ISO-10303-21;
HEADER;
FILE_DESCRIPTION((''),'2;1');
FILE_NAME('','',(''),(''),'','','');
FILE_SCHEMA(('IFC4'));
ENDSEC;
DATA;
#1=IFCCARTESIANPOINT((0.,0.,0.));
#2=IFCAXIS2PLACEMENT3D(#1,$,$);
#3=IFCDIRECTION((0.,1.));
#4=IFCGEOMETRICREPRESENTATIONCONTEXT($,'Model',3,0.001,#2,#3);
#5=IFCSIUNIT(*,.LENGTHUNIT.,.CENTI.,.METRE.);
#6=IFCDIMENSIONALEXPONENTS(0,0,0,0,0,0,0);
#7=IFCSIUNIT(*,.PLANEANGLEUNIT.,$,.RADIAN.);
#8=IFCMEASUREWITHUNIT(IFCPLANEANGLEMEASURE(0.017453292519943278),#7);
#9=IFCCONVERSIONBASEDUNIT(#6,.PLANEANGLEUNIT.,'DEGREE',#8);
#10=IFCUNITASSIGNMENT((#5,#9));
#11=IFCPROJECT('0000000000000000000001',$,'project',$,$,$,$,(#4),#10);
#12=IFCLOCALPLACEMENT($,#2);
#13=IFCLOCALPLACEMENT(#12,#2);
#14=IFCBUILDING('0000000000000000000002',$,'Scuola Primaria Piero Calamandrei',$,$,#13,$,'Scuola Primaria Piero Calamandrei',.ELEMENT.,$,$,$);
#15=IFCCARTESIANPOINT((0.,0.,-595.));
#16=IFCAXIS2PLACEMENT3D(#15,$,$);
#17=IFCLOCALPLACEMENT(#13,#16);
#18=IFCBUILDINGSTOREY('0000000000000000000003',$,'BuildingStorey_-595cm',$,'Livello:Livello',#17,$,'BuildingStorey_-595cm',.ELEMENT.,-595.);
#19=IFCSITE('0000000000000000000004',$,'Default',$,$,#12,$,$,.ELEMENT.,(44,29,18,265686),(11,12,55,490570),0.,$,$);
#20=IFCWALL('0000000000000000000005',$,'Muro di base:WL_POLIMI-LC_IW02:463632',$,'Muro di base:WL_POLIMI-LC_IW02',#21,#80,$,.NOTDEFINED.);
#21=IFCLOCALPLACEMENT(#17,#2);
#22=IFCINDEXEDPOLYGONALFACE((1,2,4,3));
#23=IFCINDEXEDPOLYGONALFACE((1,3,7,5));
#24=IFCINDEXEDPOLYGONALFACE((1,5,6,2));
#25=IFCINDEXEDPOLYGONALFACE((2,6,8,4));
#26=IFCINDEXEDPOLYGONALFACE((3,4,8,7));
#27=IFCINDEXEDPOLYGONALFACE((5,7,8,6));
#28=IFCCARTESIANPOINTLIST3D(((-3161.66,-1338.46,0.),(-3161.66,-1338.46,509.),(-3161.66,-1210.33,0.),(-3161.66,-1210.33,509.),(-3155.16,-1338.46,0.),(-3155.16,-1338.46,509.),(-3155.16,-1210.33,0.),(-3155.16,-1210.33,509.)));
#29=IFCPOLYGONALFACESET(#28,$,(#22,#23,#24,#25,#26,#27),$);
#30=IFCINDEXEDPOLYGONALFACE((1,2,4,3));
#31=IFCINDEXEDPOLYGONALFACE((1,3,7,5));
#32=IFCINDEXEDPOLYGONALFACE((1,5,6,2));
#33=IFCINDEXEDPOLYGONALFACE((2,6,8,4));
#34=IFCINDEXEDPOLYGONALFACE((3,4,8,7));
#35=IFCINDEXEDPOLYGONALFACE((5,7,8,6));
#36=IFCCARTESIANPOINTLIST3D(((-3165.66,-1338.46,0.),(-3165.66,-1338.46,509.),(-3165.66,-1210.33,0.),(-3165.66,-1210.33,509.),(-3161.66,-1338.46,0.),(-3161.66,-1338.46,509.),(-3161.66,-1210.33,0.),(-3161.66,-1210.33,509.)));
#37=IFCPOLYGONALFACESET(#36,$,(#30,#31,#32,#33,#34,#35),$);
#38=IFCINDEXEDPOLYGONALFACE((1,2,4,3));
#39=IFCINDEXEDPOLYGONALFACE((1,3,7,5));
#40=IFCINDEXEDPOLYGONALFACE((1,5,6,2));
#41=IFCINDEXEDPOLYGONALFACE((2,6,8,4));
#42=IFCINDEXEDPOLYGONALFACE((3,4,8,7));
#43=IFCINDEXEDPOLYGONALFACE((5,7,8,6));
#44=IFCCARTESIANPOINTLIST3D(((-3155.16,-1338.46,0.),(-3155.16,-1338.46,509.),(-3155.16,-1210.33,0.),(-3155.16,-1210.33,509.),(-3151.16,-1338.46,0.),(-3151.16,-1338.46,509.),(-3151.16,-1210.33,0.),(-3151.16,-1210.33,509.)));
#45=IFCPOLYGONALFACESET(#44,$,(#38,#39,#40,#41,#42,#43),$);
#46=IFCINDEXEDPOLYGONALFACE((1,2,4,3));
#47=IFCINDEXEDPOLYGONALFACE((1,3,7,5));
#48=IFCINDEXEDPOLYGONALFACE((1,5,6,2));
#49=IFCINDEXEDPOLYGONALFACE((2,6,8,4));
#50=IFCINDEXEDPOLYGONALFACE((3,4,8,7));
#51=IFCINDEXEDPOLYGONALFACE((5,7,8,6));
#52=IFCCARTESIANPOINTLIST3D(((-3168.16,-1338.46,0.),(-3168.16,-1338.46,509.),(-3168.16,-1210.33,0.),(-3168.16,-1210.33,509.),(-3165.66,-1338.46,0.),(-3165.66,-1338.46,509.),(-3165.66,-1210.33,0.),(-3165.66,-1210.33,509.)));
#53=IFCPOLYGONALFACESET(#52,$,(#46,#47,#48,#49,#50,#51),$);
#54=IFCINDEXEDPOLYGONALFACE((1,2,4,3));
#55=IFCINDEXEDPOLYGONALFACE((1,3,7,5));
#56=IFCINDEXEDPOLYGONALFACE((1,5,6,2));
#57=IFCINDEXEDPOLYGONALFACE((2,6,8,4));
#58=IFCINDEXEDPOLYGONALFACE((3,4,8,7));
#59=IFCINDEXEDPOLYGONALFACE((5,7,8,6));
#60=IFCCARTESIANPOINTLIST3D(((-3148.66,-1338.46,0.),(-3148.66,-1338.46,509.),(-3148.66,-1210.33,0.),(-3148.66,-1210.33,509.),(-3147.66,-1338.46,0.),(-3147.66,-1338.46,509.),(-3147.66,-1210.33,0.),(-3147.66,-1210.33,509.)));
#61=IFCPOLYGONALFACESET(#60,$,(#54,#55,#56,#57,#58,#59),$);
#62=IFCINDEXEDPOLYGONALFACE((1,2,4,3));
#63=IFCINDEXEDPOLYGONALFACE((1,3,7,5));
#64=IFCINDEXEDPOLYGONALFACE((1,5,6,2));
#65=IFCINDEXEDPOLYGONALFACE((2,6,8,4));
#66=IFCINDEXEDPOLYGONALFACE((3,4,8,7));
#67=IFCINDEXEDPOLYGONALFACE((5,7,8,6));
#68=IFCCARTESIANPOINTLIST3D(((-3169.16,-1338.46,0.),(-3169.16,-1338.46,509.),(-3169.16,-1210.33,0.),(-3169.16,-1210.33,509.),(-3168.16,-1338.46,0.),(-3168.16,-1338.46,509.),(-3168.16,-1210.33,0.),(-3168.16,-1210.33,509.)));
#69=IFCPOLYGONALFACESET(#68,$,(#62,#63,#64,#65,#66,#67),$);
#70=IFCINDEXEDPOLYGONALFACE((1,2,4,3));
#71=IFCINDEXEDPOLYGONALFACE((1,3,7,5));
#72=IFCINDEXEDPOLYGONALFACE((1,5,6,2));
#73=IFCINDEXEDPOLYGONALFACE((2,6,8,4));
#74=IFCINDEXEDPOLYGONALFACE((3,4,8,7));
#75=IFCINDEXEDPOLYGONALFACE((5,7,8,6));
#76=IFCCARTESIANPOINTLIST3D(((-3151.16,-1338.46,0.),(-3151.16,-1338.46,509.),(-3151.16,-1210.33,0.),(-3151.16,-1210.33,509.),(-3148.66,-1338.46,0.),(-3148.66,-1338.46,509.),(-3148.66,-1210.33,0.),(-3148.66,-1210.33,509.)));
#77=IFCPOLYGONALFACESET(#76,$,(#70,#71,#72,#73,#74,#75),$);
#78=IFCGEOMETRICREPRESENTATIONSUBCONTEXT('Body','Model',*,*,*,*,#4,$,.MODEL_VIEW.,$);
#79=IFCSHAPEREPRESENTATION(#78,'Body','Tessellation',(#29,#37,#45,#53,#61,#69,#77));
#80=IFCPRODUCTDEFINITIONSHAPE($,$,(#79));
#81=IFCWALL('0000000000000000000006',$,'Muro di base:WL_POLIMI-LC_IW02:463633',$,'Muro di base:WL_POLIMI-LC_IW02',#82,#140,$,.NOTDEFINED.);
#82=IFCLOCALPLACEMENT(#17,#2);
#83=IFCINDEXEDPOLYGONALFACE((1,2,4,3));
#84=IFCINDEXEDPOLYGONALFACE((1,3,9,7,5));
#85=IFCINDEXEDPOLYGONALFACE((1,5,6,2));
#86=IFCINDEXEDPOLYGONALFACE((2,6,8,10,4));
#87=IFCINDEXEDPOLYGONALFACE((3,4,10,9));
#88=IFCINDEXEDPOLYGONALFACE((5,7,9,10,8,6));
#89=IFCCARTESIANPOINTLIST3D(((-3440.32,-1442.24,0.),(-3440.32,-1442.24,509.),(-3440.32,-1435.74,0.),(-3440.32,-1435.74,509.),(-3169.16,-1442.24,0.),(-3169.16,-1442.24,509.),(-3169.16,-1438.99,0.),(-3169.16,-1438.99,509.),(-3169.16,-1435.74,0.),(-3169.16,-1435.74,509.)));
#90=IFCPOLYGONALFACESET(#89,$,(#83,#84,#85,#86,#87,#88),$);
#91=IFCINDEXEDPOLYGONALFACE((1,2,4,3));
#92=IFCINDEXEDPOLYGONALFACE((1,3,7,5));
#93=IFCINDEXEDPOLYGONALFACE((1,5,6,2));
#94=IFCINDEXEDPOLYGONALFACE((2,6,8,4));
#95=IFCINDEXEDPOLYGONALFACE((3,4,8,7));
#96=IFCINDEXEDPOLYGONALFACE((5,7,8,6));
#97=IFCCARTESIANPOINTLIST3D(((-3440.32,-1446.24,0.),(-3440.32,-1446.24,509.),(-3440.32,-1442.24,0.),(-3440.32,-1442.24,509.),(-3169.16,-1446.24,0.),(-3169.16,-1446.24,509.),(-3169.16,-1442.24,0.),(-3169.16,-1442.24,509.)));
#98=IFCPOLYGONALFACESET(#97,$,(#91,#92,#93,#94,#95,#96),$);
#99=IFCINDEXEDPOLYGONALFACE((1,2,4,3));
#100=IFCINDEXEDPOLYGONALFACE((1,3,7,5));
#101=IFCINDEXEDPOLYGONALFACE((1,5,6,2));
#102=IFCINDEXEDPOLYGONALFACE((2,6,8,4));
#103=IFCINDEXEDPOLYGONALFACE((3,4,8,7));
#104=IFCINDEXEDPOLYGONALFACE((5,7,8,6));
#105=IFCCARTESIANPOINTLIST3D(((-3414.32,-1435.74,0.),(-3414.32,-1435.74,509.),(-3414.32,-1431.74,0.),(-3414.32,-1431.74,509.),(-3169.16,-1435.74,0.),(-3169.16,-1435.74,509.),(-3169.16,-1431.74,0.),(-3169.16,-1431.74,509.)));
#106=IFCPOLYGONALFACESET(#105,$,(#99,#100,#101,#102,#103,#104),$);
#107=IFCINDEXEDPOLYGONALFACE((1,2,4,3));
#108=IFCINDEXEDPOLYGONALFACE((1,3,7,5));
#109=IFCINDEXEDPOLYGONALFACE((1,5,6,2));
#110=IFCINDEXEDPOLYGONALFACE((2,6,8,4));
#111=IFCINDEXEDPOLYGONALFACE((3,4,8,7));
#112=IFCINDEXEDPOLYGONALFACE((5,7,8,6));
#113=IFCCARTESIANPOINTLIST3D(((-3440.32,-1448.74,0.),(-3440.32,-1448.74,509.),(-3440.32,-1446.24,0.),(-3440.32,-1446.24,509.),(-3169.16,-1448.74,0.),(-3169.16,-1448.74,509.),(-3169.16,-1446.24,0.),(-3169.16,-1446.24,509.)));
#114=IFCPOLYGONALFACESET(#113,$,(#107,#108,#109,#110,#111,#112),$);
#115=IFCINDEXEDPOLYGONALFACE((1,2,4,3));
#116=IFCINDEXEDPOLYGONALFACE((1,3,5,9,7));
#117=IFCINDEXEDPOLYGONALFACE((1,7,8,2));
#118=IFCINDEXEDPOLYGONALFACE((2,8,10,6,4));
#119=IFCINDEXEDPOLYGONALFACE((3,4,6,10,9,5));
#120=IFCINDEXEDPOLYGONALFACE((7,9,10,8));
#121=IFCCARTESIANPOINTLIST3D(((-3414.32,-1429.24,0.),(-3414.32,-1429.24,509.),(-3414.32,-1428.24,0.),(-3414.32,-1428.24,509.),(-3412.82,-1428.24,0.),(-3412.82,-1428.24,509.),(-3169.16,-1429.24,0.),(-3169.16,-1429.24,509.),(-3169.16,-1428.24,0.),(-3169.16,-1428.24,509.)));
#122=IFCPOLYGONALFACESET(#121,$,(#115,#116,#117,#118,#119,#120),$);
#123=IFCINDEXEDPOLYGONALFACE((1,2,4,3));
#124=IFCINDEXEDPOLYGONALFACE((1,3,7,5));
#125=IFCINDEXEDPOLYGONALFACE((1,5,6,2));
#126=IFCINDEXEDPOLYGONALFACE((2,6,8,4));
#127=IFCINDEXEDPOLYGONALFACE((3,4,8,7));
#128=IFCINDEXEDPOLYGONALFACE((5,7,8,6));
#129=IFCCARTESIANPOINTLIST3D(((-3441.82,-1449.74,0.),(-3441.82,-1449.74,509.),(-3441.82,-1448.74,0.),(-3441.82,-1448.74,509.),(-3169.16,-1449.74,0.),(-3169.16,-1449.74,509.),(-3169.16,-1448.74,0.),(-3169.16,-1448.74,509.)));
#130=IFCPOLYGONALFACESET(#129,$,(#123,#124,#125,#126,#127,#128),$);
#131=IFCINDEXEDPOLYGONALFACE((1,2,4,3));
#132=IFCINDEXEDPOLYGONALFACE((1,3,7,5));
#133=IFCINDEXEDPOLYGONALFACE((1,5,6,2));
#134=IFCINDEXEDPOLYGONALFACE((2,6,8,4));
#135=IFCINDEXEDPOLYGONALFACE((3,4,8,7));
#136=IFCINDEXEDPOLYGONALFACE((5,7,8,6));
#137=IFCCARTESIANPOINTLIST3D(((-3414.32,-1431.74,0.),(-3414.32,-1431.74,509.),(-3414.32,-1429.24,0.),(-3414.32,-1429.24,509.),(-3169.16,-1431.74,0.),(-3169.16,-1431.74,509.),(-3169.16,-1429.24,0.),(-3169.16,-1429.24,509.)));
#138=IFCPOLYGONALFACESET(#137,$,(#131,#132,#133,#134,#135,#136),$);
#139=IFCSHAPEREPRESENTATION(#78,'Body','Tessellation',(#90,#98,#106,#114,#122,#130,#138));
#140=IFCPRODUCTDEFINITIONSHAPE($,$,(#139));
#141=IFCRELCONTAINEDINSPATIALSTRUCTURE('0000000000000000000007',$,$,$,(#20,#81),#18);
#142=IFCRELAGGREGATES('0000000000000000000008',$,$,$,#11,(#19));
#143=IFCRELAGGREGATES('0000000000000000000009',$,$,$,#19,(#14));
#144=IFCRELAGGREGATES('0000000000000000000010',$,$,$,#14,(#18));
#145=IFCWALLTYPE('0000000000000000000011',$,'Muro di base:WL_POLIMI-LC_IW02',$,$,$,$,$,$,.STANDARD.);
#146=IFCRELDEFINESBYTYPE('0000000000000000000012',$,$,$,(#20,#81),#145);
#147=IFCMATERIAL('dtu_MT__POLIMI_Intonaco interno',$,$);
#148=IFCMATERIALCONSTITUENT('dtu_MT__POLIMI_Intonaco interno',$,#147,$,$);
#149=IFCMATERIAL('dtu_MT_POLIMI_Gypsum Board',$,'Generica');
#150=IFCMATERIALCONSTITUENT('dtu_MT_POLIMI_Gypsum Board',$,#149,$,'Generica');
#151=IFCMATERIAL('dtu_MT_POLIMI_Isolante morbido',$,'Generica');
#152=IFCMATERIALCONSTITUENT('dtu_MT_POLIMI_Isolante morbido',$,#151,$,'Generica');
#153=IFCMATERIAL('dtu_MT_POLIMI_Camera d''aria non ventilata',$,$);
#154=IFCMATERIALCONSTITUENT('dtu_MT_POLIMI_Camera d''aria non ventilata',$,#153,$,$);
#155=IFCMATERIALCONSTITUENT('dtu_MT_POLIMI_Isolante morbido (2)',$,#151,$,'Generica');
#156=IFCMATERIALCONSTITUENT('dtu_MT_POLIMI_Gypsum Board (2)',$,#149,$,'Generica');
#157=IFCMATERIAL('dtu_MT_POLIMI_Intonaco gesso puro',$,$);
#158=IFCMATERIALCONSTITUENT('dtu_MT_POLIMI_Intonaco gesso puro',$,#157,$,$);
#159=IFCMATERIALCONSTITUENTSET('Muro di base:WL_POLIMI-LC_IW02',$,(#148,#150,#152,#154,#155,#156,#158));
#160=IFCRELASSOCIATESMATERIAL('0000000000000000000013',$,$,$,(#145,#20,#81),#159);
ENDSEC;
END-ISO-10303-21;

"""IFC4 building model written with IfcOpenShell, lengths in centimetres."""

from ifc_helpers import new_model, entity, si_unit, converted_unit, direction, frame, origin, place, context, subcontext, project, spatial, indexed_curve, outline, extrude, material, constituent, constituent_set, type_object, element, save


model = new_model("IFC4")

# Units and contexts
model_context = context("Model", 3, precision=0.001, world=origin(), true_north=direction((0.0, 1.0)))
body_context = subcontext(model_context, "Body", "Model", "MODEL_VIEW")
ifc_project = project(units=[si_unit("LENGTHUNIT", "METRE", prefix="CENTI"), converted_unit("PLANEANGLEUNIT", "DEGREE", entity("IfcPlaneAngleMeasure", 0.017453292519943278), si_unit("PLANEANGLEUNIT", "RADIAN"), dimensions=[0, 0, 0, 0, 0, 0, 0])], contexts=[model_context])

# Site, building, storey
site_placement = place(None, origin())
site = spatial("IfcSite", under=ifc_project, at=site_placement, Name="Default", CompositionType="ELEMENT", RefLatitude=(44, 29, 18, 265686), RefLongitude=(11, 12, 55, 490570), RefElevation=0.0)
building_placement = place(site_placement, origin())
building = spatial("IfcBuilding", under=site, at=building_placement, Name="Scuola Primaria Piero Calamandrei", LongName="Scuola Primaria Piero Calamandrei", CompositionType="ELEMENT")
storey_placement = place(building_placement, frame((0.0, 0.0, -595.0)))
storey = spatial("IfcBuildingStorey", under=building, at=storey_placement, Name="BuildingStorey_-595cm", ObjectType="Livello:Livello", LongName="BuildingStorey_-595cm", CompositionType="ELEMENT", Elevation=-595.0)

# Shared definitions
ifc_material_1 = material(Name="dtu_MT__POLIMI_Intonaco interno")

# Shared definitions
ifc_constituent_1 = constituent(ifc_material_1, Name="dtu_MT__POLIMI_Intonaco interno")
ifc_material_2 = material(Name="dtu_MT_POLIMI_Gypsum Board", Category="Generica")
ifc_constituent_2 = constituent(ifc_material_2, Name="dtu_MT_POLIMI_Gypsum Board", Category="Generica")
ifc_material_3 = material(Name="dtu_MT_POLIMI_Isolante morbido", Category="Generica")
ifc_constituent_3 = constituent(ifc_material_3, Name="dtu_MT_POLIMI_Isolante morbido", Category="Generica")
ifc_material_4 = material(Name="dtu_MT_POLIMI_Camera d'aria non ventilata")
ifc_constituent_4 = constituent(ifc_material_4, Name="dtu_MT_POLIMI_Camera d'aria non ventilata")
ifc_constituent_5 = constituent(ifc_material_3, Name="dtu_MT_POLIMI_Isolante morbido (2)", Category="Generica")
ifc_constituent_6 = constituent(ifc_material_2, Name="dtu_MT_POLIMI_Gypsum Board (2)", Category="Generica")
ifc_material_5 = material(Name="dtu_MT_POLIMI_Intonaco gesso puro")
ifc_constituent_7 = constituent(ifc_material_5, Name="dtu_MT_POLIMI_Intonaco gesso puro")
ifc_constituent_set_1 = constituent_set(constituents=[ifc_constituent_1, ifc_constituent_2, ifc_constituent_3, ifc_constituent_4, ifc_constituent_5, ifc_constituent_6, ifc_constituent_7], Name="Muro di base:WL_POLIMI-LC_IW02")
wall_type_1 = type_object("IfcWallType", Name="Muro di base:WL_POLIMI-LC_IW02", PredefinedType="STANDARD", material=ifc_constituent_set_1)

# Walls
wall_1_placement = place(storey_placement, frame((-3158.41, -1338.46, 0.0), z_axis=(0.0, 0.0, 1.0), x_axis=(0.0, 1.0, 0.0)))
element("IfcWall", 1, at=wall_1_placement, inside=storey, type_object=wall_type_1, material=ifc_constituent_set_1, Name="Muro di base:WL_POLIMI-LC_IW02:463632", ObjectType="Muro di base:WL_POLIMI-LC_IW02", PredefinedType="NOTDEFINED", context=body_context, shape_type="SweptSolid", body=[
    extrude(outline(indexed_curve([(-64.07, -3.25), (64.07, -3.25), (64.07, 3.25), (-64.07, 3.25), (-64.07, -3.25)], self_intersect=False)), frame((64.07, 0.0, 0.0)), (0.0, 0.0, 1.0), 509.0),
    extrude(outline(indexed_curve([(-64.07, -2.0), (64.07, -2.0), (64.07, 2.0), (-64.07, 2.0), (-64.07, -2.0)], self_intersect=False)), frame((64.07, 5.25, 0.0)), (0.0, 0.0, 1.0), 509.0),
    extrude(outline(indexed_curve([(-64.07, -2.0), (64.07, -2.0), (64.07, 2.0), (-64.07, 2.0), (-64.07, -2.0)], self_intersect=False)), frame((64.07, -5.25, 0.0)), (0.0, 0.0, 1.0), 509.0),
    extrude(outline(indexed_curve([(-64.07, -1.25), (64.07, -1.25), (64.07, 1.25), (-64.07, 1.25), (-64.07, -1.25)], self_intersect=False)), frame((64.07, 8.5, 0.0)), (0.0, 0.0, 1.0), 509.0),
    extrude(outline(indexed_curve([(-0.5, -64.07), (0.5, -64.07), (0.5, 64.07), (-0.5, 64.07), (-0.5, -64.07)], self_intersect=False)), frame((64.07, -10.25, 0.0), z_axis=(0.0, 0.0, 1.0), x_axis=(0.0, 1.0, 0.0)), (0.0, 0.0, 1.0), 509.0),
    extrude(outline(indexed_curve([(-0.5, -64.07), (0.5, -64.07), (0.5, 64.07), (-0.5, 64.07), (-0.5, -64.07)], self_intersect=False)), frame((64.07, 10.25, 0.0), z_axis=(0.0, 0.0, 1.0), x_axis=(0.0, -1.0, 0.0)), (0.0, 0.0, 1.0), 509.0),
    extrude(outline(indexed_curve([(-64.07, -1.25), (64.07, -1.25), (64.07, 1.25), (-64.07, 1.25), (-64.07, -1.25)], self_intersect=False)), frame((64.07, -8.5, 0.0)), (0.0, 0.0, 1.0), 509.0),
])
wall_2_placement = place(storey_placement, frame((-3169.16, -1438.99, 0.0), z_axis=(0.0, 0.0, 1.0), x_axis=(-1.0, 0.0, 0.0)))
element("IfcWall", 2, at=wall_2_placement, inside=storey, type_object=wall_type_1, material=ifc_constituent_set_1, Name="Muro di base:WL_POLIMI-LC_IW02:463633", ObjectType="Muro di base:WL_POLIMI-LC_IW02", PredefinedType="NOTDEFINED", context=body_context, shape_type="SweptSolid", body=[
    extrude(outline(indexed_curve([(-108.46, -3.25), (162.7, -3.25), (162.7, 3.25), (-108.46, 3.25), (-108.46, 0.0), (-108.46, -3.25)], self_intersect=False)), frame((108.46, 0.0, 0.0)), (0.0, 0.0, 1.0), 509.0),
    extrude(outline(indexed_curve([(-135.58, -2.0), (135.58, -2.0), (135.58, 2.0), (-135.58, 2.0), (-135.58, -2.0)], self_intersect=False)), frame((135.58, 5.25, 0.0)), (0.0, 0.0, 1.0), 509.0),
    extrude(outline(indexed_curve([(-122.58, -2.0), (122.58, -2.0), (122.58, 2.0), (-122.58, 2.0), (-122.58, -2.0)], self_intersect=False)), frame((122.58, -5.25, 0.0)), (0.0, 0.0, 1.0), 509.0),
    extrude(outline(indexed_curve([(-135.58, -1.25), (135.58, -1.25), (135.58, 1.25), (-135.58, 1.25), (-135.58, -1.25)], self_intersect=False)), frame((135.58, 8.5, 0.0)), (0.0, 0.0, 1.0), 509.0),
    extrude(outline(indexed_curve([(96.86, -0.4), (98.36, -0.4), (98.36, 0.6), (-146.8, 0.6), (-146.8, -0.4), (96.86, -0.4)], self_intersect=False)), frame((146.8, -10.35, 0.0)), (0.0, 0.0, 1.0), 509.0),
    extrude(outline(indexed_curve([(-0.5, -136.33), (0.5, -136.33), (0.5, 136.33), (-0.5, 136.33), (-0.5, -136.33)], self_intersect=False)), frame((136.33, 10.25, 0.0), z_axis=(0.0, 0.0, 1.0), x_axis=(0.0, -1.0, 0.0)), (0.0, 0.0, 1.0), 509.0),
    extrude(outline(indexed_curve([(-122.58, -1.25), (122.58, -1.25), (122.58, 1.25), (-122.58, 1.25), (-122.58, -1.25)], self_intersect=False)), frame((122.58, -8.5, 0.0)), (0.0, 0.0, 1.0), 509.0),
])

save(model, "model.ifc")
